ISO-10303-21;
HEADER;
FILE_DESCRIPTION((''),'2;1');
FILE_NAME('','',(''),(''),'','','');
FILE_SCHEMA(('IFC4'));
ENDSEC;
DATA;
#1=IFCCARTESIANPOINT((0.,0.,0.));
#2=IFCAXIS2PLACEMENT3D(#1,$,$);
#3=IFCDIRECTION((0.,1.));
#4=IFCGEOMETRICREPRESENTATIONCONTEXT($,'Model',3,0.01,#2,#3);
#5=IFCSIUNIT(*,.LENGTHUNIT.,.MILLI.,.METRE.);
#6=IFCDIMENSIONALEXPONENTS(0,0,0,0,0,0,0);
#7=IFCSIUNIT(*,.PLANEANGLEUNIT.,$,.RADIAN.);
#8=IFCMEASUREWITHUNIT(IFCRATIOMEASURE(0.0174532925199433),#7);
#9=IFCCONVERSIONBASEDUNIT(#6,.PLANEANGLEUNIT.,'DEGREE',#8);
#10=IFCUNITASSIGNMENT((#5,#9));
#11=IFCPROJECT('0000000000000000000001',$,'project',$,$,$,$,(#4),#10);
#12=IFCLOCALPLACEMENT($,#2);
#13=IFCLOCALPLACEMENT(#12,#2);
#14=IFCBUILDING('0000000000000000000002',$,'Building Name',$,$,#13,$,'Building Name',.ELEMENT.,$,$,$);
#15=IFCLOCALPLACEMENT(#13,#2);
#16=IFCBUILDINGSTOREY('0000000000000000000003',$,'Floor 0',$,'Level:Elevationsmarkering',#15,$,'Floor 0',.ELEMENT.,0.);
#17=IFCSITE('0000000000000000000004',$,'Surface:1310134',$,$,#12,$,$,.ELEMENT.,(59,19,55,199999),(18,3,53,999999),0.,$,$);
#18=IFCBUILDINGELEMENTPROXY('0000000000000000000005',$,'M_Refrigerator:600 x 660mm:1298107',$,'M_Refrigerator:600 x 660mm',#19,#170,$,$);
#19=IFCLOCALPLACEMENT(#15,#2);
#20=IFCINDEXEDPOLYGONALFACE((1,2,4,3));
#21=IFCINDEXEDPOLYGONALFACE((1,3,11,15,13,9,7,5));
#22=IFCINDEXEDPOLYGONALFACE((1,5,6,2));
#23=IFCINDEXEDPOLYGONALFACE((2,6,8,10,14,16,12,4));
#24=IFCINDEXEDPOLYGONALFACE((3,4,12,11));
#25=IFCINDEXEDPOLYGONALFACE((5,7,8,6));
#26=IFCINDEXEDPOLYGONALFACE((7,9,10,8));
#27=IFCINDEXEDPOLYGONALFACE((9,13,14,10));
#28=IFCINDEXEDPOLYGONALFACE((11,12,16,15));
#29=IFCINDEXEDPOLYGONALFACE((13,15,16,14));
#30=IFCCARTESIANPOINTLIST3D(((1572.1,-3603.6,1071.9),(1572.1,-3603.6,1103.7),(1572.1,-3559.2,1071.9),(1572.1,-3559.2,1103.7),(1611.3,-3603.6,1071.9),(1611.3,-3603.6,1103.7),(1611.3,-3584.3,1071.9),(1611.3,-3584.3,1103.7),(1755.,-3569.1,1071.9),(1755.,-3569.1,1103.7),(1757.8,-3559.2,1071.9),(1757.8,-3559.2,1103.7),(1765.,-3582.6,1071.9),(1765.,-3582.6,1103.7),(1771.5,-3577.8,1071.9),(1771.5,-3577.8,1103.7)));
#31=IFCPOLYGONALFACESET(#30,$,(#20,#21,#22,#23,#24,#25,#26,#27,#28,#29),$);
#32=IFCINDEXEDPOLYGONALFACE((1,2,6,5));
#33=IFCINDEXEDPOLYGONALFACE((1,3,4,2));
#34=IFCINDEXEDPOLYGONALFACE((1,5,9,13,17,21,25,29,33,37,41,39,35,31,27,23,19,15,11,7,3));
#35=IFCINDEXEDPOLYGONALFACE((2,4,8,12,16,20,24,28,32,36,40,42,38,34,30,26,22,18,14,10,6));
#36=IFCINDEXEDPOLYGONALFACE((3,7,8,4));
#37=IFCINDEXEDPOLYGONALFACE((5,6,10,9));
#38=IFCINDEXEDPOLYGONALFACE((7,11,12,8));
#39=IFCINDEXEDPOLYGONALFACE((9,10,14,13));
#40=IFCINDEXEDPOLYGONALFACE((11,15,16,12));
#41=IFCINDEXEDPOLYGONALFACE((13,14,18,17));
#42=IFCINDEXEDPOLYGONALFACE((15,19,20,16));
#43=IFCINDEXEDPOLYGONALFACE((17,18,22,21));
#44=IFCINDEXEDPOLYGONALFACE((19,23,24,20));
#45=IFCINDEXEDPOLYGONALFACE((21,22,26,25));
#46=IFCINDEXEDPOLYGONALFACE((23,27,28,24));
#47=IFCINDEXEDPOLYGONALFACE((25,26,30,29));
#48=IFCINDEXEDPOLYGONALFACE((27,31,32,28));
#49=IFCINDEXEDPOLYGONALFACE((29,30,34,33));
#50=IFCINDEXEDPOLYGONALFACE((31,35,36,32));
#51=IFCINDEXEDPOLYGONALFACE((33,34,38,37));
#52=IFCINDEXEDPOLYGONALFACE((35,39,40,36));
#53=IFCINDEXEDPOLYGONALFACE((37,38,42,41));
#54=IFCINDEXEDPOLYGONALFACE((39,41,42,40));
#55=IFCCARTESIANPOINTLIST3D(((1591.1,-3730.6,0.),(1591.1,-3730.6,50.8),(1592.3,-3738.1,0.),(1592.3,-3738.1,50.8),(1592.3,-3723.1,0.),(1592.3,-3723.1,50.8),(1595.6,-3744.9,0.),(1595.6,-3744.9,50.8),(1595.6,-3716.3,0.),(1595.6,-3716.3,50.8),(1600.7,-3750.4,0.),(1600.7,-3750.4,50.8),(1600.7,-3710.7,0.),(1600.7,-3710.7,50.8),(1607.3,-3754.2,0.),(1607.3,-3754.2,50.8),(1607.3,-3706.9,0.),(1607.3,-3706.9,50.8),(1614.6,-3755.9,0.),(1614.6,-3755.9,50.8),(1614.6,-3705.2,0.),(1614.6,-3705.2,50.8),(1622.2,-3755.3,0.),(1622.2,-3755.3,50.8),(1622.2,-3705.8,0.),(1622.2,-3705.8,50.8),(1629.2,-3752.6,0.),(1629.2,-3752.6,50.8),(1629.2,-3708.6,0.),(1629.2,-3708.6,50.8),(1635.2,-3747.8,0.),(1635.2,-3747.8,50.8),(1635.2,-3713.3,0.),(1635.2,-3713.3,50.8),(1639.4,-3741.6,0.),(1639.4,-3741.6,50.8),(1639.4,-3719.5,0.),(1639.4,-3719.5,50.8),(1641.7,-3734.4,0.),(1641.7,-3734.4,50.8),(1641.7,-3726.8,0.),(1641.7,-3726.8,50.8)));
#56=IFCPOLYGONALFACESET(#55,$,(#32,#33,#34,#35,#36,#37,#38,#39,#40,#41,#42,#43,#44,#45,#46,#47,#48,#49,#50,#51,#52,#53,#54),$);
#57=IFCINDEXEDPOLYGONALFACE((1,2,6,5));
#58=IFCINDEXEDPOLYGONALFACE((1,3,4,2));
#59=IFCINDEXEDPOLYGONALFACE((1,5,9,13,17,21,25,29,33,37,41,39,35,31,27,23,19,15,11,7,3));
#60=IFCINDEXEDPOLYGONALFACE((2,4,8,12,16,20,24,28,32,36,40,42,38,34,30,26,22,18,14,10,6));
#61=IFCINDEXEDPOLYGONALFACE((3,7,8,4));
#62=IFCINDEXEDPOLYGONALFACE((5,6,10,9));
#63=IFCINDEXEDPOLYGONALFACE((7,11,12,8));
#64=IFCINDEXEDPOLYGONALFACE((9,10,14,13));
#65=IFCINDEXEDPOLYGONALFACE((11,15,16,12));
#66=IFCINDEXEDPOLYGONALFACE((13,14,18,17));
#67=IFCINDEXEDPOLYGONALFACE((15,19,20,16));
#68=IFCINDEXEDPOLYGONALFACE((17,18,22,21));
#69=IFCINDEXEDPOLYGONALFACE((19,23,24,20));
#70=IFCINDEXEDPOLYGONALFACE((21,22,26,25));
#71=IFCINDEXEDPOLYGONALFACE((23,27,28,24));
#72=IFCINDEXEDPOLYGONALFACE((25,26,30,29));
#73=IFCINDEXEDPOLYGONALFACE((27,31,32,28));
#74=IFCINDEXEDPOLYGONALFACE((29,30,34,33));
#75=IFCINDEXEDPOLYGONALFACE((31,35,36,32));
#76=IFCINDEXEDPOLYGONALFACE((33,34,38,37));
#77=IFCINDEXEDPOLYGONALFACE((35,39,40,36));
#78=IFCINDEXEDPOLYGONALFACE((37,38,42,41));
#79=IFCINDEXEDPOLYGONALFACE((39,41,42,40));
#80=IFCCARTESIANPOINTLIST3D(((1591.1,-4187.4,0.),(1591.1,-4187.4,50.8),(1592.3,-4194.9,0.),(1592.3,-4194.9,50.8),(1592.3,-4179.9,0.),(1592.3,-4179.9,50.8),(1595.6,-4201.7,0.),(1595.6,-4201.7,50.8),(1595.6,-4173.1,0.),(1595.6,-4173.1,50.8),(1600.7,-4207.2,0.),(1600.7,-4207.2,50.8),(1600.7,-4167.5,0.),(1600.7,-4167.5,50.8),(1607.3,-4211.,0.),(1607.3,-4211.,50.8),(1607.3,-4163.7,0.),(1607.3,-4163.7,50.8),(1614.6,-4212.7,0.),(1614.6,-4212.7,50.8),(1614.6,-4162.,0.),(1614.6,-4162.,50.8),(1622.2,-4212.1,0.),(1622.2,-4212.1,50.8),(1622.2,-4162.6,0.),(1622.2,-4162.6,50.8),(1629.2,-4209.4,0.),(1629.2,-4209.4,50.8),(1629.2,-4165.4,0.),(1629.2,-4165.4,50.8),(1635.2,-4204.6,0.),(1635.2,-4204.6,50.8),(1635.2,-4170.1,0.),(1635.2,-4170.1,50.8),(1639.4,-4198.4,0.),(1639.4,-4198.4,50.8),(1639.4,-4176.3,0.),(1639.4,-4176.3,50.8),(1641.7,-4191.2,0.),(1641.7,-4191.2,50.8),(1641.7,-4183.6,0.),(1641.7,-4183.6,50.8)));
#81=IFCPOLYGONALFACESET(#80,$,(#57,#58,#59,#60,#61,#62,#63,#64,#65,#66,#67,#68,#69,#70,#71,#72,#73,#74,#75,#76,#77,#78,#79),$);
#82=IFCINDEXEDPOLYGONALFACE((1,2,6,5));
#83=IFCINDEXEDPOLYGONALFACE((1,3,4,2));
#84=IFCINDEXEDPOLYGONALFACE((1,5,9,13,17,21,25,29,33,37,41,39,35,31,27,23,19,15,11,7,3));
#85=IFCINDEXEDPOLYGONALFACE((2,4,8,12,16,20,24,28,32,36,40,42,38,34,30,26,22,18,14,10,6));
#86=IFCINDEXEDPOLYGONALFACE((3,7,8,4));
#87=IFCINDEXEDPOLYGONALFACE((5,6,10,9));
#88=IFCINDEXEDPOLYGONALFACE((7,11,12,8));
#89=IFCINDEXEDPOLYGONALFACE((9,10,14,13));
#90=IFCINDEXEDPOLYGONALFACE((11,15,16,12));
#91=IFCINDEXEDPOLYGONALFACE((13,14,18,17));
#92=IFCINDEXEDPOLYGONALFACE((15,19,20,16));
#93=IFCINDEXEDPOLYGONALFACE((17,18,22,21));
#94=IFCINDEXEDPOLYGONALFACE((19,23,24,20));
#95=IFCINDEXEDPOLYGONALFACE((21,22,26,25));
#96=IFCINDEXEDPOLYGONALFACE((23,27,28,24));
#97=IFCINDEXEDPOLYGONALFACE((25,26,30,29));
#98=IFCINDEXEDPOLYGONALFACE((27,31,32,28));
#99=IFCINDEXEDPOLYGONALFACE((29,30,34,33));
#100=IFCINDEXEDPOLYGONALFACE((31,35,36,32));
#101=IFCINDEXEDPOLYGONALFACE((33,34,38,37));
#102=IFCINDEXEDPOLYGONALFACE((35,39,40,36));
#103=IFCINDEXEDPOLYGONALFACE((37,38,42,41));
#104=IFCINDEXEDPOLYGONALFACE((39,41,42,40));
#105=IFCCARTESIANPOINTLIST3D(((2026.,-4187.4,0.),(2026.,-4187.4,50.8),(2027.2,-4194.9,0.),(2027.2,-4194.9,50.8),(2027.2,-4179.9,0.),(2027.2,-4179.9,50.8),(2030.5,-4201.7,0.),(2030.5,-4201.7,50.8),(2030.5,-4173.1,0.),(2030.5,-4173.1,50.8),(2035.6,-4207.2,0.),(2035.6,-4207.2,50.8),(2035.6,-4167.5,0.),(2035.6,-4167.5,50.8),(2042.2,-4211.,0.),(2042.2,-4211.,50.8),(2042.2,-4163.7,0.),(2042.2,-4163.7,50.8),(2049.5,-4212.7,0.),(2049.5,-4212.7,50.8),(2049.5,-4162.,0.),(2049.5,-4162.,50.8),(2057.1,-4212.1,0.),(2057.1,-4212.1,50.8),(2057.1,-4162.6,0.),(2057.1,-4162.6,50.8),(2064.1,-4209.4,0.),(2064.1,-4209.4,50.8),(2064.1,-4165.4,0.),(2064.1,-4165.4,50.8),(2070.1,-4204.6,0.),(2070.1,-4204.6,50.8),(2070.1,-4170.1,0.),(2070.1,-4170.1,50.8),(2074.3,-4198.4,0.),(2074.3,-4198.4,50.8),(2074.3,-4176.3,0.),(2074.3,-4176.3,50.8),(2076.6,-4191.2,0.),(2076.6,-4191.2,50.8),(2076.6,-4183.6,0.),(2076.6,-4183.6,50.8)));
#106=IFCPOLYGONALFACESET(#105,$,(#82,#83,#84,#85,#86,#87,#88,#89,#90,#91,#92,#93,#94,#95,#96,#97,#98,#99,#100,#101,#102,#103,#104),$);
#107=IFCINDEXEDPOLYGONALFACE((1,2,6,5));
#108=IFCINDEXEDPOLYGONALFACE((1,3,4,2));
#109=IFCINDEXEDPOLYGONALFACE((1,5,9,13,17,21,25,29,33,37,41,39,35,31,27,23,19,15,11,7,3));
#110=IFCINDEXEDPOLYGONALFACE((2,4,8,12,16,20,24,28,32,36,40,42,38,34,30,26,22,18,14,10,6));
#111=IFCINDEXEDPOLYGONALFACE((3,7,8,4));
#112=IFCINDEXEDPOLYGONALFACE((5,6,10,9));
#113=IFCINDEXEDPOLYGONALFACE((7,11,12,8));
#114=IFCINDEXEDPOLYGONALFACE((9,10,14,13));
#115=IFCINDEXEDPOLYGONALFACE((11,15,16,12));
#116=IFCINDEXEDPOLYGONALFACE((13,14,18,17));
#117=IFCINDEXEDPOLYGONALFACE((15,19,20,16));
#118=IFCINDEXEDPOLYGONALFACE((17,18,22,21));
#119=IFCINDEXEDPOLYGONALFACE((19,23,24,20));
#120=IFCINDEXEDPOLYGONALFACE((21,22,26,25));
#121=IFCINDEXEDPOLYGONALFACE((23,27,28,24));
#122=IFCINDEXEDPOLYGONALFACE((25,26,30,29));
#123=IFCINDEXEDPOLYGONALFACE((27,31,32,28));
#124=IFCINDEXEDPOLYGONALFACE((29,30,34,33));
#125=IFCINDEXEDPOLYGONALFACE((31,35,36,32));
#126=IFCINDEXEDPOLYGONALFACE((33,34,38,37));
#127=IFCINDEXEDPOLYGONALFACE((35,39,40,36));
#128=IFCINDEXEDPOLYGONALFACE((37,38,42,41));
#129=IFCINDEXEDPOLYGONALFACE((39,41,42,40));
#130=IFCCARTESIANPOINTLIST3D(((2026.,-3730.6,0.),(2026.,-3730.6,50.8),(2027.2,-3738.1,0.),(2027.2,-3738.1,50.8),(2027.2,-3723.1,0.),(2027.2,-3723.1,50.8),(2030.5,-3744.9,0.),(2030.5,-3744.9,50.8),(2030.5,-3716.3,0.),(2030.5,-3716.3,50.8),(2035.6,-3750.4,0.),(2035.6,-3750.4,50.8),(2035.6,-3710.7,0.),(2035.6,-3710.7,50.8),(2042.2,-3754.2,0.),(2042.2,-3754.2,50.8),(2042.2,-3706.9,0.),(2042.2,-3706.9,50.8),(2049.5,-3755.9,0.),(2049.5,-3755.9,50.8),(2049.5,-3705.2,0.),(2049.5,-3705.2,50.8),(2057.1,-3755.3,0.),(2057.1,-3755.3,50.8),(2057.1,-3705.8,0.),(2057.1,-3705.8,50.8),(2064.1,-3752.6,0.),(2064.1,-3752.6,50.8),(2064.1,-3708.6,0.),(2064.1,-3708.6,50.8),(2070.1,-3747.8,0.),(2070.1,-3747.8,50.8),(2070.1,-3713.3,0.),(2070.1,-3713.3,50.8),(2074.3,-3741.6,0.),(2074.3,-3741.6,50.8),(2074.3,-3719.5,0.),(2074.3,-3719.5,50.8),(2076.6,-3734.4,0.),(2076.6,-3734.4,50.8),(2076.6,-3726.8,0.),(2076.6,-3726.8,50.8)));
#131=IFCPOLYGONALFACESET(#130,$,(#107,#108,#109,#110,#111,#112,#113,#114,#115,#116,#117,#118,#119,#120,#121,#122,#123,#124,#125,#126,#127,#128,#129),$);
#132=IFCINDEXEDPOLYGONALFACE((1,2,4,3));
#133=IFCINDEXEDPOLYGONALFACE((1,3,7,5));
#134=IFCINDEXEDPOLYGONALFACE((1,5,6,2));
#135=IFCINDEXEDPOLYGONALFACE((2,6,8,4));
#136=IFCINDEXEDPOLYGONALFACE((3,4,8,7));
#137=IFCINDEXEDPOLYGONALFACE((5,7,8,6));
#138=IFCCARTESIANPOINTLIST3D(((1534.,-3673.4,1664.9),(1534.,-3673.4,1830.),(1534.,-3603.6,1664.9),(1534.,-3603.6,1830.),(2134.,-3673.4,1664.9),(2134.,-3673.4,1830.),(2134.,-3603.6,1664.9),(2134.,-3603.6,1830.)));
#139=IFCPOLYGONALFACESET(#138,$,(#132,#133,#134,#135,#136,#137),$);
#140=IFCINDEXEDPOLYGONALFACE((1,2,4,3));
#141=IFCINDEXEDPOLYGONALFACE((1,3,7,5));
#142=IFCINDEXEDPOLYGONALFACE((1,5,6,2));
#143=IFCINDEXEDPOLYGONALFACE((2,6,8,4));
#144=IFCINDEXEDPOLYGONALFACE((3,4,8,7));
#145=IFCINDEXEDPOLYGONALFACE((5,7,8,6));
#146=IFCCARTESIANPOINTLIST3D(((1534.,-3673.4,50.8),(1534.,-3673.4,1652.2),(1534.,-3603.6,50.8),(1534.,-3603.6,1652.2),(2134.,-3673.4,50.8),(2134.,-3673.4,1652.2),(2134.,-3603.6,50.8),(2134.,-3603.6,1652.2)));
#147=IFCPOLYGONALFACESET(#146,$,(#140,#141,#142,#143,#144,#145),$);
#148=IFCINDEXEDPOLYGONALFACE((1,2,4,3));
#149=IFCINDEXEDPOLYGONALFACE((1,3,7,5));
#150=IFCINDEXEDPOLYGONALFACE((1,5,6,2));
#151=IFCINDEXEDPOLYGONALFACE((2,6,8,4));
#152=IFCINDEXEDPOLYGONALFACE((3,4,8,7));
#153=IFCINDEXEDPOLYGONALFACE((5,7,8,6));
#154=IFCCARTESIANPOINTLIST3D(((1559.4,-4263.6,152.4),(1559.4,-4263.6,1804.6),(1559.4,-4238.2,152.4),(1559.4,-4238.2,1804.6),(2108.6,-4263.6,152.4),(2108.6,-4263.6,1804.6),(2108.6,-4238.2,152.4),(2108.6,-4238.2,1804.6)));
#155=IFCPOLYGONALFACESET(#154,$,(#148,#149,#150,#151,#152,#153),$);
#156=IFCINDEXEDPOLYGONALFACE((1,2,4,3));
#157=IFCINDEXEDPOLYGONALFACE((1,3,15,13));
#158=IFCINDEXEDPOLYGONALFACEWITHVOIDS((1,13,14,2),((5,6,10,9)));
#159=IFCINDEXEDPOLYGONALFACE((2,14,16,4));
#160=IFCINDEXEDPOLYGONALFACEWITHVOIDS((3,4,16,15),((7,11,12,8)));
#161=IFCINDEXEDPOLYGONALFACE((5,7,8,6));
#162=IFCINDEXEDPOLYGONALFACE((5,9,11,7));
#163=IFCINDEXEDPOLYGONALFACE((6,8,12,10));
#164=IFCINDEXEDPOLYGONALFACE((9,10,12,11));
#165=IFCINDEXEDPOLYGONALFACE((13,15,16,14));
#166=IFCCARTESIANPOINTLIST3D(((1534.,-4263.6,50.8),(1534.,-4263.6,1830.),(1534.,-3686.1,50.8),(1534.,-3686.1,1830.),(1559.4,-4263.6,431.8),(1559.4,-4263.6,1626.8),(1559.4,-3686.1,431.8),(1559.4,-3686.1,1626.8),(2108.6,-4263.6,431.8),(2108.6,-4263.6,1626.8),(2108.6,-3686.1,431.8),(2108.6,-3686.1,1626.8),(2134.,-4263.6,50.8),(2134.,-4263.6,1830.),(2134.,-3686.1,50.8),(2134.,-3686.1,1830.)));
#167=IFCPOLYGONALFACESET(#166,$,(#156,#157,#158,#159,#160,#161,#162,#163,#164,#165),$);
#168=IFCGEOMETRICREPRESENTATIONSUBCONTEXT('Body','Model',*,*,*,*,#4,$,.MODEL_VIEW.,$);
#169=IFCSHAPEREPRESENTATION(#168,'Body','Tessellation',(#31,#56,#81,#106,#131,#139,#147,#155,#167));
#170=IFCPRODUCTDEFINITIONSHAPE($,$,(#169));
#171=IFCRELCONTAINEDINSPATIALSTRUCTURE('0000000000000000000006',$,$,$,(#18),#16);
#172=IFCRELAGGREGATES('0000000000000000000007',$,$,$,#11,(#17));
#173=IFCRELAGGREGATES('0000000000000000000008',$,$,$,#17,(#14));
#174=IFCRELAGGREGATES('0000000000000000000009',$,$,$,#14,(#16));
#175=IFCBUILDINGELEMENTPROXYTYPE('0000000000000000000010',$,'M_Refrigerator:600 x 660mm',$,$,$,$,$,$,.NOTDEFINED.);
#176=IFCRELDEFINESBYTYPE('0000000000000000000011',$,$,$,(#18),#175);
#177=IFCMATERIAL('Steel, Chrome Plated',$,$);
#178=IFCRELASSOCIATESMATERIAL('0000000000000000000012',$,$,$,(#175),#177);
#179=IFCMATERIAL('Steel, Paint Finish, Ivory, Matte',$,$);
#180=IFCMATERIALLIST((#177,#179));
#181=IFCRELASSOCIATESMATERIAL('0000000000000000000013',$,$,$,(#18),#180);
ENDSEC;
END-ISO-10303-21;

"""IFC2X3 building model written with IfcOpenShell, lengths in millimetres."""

from ifc_helpers import new_model, entity, si_unit, converted_unit, direction, frame, frame_2d, origin, origin_2d_with_axis, place, context, subcontext, project, spatial, polyline, rectangle, circle, outline, extrude, source, transform, mapped, material, material_list, type_object, type_shapes, element, save


model = new_model("IFC2X3")

# Units and contexts
model_context = context("Model", 3, precision=0.01, world=origin(), true_north=direction((0.0, 1.0)))
body_context = subcontext(model_context, "Body", "Model", "MODEL_VIEW")
ifc_project = project(units=[si_unit("LENGTHUNIT", "METRE", prefix="MILLI"), converted_unit("PLANEANGLEUNIT", "DEGREE", entity("IfcRatioMeasure", 0.0174532925199433), si_unit("PLANEANGLEUNIT", "RADIAN"), dimensions=[0, 0, 0, 0, 0, 0, 0])], contexts=[model_context])

# Site, building, storey
site_placement = place(None, origin())
site = spatial("IfcSite", under=ifc_project, at=site_placement, Name="Surface:1310134", CompositionType="ELEMENT", RefLatitude=(59, 19, 55, 199999), RefLongitude=(18, 3, 53, 999999), RefElevation=0.0)
building_placement = place(site_placement, origin())
building = spatial("IfcBuilding", under=site, at=building_placement, Name="Building Name", LongName="Building Name", CompositionType="ELEMENT")
storey_placement = place(building_placement, origin())
storey = spatial("IfcBuildingStorey", under=building, at=storey_placement, Name="Floor 0", ObjectType="Level:Elevationsmarkering", LongName="Floor 0", CompositionType="ELEMENT", Elevation=0.0)

# Shared definitions
ifc_material_1 = material(Name="Steel, Chrome Plated")

# Building element proxy
ifc_material_2 = material(Name="Steel, Paint Finish, Ivory, Matte")
ifc_material_list_1 = material_list([ifc_material_1, ifc_material_2])
building_element_proxy_type_1 = type_object("IfcBuildingElementProxyType", Name="M_Refrigerator:600 x 660mm", PredefinedType="NOTDEFINED", material=ifc_material_1)
shared_shape_1 = source(origin(), body_context, "Body", "SweptSolid", [
    extrude(outline(polyline([(-20.7, -104.9), (23.6, -104.9), (23.6, -65.7), (4.4, -65.7), (-10.8, 78.0), (2.7, 88.0), (-2.1, 94.5), (-20.7, 80.8), (-20.7, -104.9)])), frame((103.2, -387.4, 1071.9), z_axis=(0.0, 0.0, 1.0), x_axis=(0.0, 1.0, 0.0)), (0.0, 0.0, 1.0), 31.8),
    extrude(circle(Radius=25.4, at=frame_2d((0.0, 0.0), x_axis=(1.0, 0.0))), frame((163.6, -236.8, 0.0)), (0.0, 0.0, 1.0), 50.8),
    extrude(circle(Radius=25.4, at=frame_2d((0.0, 0.0), x_axis=(1.0, 0.0))), frame((163.6, 220.0, 0.0)), (0.0, 0.0, 1.0), 50.8),
    extrude(circle(Radius=25.4, at=frame_2d((0.0, 0.0), x_axis=(1.0, 0.0))), frame((-271.3, 220.0, 0.0)), (0.0, 0.0, 1.0), 50.8),
    extrude(circle(Radius=25.4, at=frame_2d((0.0, 0.0), x_axis=(1.0, 0.0))), frame((-271.3, -236.8, 0.0)), (0.0, 0.0, 1.0), 50.8),
    extrude(rectangle(XDim=69.8, YDim=600.0, at=frame_2d((0.0, 0.0), x_axis=(1.0, 0.0))), frame((-53.8, -328.9, 1664.9), z_axis=(0.0, 0.0, 1.0), x_axis=(0.0, 1.0, 0.0)), (0.0, 0.0, 1.0), 165.1),
    extrude(rectangle(XDim=69.8, YDim=600.0, at=frame_2d((0.0, 0.0), x_axis=(1.0, 0.0))), frame((-53.8, -328.9, 50.8), z_axis=(0.0, 0.0, 1.0), x_axis=(0.0, 1.0, 0.0)), (0.0, 0.0, 1.0), 1601.4),
    extrude(rectangle(XDim=25.4, YDim=549.2, at=origin_2d_with_axis()), frame((-53.8, 283.5, 152.4), z_axis=(0.0, 0.0, 1.0), x_axis=(0.0, 1.0, 0.0)), (0.0, 0.0, 1.0), 1652.2),
    extrude(outline(polyline([(-889.6, -300.0), (889.6, -300.0), (889.6, 300.0), (-889.6, 300.0), (-889.6, -300.0)]), holes=[polyline([(-686.4, -274.6), (-686.4, 274.6), (508.6, 274.6), (508.6, -274.6), (-686.4, -274.6)])]), frame((-53.8, -281.2, 940.4), z_axis=(0.0, 1.0, 0.0), x_axis=(0.0, 0.0, -1.0)), (0.0, 0.0, 1.0), 577.5),
])
type_shapes(building_element_proxy_type_1, [shared_shape_1])
proxy_1_placement = place(storey_placement, frame((1780.2, -3967.4, 0.0), z_axis=(0.0, 0.0, 1.0), x_axis=(-1.0, 0.0, 0.0)))
element("IfcBuildingElementProxy", 1, at=proxy_1_placement, inside=storey, type_object=building_element_proxy_type_1, material=ifc_material_list_1, Name="M_Refrigerator:600 x 660mm:1298107", ObjectType="M_Refrigerator:600 x 660mm", context=body_context, shape_type="MappedRepresentation", body=[
    mapped(shared_shape_1, transform((0.0, 0.0, 0.0), scale=1.0)),
])

save(model, "model.ifc")
